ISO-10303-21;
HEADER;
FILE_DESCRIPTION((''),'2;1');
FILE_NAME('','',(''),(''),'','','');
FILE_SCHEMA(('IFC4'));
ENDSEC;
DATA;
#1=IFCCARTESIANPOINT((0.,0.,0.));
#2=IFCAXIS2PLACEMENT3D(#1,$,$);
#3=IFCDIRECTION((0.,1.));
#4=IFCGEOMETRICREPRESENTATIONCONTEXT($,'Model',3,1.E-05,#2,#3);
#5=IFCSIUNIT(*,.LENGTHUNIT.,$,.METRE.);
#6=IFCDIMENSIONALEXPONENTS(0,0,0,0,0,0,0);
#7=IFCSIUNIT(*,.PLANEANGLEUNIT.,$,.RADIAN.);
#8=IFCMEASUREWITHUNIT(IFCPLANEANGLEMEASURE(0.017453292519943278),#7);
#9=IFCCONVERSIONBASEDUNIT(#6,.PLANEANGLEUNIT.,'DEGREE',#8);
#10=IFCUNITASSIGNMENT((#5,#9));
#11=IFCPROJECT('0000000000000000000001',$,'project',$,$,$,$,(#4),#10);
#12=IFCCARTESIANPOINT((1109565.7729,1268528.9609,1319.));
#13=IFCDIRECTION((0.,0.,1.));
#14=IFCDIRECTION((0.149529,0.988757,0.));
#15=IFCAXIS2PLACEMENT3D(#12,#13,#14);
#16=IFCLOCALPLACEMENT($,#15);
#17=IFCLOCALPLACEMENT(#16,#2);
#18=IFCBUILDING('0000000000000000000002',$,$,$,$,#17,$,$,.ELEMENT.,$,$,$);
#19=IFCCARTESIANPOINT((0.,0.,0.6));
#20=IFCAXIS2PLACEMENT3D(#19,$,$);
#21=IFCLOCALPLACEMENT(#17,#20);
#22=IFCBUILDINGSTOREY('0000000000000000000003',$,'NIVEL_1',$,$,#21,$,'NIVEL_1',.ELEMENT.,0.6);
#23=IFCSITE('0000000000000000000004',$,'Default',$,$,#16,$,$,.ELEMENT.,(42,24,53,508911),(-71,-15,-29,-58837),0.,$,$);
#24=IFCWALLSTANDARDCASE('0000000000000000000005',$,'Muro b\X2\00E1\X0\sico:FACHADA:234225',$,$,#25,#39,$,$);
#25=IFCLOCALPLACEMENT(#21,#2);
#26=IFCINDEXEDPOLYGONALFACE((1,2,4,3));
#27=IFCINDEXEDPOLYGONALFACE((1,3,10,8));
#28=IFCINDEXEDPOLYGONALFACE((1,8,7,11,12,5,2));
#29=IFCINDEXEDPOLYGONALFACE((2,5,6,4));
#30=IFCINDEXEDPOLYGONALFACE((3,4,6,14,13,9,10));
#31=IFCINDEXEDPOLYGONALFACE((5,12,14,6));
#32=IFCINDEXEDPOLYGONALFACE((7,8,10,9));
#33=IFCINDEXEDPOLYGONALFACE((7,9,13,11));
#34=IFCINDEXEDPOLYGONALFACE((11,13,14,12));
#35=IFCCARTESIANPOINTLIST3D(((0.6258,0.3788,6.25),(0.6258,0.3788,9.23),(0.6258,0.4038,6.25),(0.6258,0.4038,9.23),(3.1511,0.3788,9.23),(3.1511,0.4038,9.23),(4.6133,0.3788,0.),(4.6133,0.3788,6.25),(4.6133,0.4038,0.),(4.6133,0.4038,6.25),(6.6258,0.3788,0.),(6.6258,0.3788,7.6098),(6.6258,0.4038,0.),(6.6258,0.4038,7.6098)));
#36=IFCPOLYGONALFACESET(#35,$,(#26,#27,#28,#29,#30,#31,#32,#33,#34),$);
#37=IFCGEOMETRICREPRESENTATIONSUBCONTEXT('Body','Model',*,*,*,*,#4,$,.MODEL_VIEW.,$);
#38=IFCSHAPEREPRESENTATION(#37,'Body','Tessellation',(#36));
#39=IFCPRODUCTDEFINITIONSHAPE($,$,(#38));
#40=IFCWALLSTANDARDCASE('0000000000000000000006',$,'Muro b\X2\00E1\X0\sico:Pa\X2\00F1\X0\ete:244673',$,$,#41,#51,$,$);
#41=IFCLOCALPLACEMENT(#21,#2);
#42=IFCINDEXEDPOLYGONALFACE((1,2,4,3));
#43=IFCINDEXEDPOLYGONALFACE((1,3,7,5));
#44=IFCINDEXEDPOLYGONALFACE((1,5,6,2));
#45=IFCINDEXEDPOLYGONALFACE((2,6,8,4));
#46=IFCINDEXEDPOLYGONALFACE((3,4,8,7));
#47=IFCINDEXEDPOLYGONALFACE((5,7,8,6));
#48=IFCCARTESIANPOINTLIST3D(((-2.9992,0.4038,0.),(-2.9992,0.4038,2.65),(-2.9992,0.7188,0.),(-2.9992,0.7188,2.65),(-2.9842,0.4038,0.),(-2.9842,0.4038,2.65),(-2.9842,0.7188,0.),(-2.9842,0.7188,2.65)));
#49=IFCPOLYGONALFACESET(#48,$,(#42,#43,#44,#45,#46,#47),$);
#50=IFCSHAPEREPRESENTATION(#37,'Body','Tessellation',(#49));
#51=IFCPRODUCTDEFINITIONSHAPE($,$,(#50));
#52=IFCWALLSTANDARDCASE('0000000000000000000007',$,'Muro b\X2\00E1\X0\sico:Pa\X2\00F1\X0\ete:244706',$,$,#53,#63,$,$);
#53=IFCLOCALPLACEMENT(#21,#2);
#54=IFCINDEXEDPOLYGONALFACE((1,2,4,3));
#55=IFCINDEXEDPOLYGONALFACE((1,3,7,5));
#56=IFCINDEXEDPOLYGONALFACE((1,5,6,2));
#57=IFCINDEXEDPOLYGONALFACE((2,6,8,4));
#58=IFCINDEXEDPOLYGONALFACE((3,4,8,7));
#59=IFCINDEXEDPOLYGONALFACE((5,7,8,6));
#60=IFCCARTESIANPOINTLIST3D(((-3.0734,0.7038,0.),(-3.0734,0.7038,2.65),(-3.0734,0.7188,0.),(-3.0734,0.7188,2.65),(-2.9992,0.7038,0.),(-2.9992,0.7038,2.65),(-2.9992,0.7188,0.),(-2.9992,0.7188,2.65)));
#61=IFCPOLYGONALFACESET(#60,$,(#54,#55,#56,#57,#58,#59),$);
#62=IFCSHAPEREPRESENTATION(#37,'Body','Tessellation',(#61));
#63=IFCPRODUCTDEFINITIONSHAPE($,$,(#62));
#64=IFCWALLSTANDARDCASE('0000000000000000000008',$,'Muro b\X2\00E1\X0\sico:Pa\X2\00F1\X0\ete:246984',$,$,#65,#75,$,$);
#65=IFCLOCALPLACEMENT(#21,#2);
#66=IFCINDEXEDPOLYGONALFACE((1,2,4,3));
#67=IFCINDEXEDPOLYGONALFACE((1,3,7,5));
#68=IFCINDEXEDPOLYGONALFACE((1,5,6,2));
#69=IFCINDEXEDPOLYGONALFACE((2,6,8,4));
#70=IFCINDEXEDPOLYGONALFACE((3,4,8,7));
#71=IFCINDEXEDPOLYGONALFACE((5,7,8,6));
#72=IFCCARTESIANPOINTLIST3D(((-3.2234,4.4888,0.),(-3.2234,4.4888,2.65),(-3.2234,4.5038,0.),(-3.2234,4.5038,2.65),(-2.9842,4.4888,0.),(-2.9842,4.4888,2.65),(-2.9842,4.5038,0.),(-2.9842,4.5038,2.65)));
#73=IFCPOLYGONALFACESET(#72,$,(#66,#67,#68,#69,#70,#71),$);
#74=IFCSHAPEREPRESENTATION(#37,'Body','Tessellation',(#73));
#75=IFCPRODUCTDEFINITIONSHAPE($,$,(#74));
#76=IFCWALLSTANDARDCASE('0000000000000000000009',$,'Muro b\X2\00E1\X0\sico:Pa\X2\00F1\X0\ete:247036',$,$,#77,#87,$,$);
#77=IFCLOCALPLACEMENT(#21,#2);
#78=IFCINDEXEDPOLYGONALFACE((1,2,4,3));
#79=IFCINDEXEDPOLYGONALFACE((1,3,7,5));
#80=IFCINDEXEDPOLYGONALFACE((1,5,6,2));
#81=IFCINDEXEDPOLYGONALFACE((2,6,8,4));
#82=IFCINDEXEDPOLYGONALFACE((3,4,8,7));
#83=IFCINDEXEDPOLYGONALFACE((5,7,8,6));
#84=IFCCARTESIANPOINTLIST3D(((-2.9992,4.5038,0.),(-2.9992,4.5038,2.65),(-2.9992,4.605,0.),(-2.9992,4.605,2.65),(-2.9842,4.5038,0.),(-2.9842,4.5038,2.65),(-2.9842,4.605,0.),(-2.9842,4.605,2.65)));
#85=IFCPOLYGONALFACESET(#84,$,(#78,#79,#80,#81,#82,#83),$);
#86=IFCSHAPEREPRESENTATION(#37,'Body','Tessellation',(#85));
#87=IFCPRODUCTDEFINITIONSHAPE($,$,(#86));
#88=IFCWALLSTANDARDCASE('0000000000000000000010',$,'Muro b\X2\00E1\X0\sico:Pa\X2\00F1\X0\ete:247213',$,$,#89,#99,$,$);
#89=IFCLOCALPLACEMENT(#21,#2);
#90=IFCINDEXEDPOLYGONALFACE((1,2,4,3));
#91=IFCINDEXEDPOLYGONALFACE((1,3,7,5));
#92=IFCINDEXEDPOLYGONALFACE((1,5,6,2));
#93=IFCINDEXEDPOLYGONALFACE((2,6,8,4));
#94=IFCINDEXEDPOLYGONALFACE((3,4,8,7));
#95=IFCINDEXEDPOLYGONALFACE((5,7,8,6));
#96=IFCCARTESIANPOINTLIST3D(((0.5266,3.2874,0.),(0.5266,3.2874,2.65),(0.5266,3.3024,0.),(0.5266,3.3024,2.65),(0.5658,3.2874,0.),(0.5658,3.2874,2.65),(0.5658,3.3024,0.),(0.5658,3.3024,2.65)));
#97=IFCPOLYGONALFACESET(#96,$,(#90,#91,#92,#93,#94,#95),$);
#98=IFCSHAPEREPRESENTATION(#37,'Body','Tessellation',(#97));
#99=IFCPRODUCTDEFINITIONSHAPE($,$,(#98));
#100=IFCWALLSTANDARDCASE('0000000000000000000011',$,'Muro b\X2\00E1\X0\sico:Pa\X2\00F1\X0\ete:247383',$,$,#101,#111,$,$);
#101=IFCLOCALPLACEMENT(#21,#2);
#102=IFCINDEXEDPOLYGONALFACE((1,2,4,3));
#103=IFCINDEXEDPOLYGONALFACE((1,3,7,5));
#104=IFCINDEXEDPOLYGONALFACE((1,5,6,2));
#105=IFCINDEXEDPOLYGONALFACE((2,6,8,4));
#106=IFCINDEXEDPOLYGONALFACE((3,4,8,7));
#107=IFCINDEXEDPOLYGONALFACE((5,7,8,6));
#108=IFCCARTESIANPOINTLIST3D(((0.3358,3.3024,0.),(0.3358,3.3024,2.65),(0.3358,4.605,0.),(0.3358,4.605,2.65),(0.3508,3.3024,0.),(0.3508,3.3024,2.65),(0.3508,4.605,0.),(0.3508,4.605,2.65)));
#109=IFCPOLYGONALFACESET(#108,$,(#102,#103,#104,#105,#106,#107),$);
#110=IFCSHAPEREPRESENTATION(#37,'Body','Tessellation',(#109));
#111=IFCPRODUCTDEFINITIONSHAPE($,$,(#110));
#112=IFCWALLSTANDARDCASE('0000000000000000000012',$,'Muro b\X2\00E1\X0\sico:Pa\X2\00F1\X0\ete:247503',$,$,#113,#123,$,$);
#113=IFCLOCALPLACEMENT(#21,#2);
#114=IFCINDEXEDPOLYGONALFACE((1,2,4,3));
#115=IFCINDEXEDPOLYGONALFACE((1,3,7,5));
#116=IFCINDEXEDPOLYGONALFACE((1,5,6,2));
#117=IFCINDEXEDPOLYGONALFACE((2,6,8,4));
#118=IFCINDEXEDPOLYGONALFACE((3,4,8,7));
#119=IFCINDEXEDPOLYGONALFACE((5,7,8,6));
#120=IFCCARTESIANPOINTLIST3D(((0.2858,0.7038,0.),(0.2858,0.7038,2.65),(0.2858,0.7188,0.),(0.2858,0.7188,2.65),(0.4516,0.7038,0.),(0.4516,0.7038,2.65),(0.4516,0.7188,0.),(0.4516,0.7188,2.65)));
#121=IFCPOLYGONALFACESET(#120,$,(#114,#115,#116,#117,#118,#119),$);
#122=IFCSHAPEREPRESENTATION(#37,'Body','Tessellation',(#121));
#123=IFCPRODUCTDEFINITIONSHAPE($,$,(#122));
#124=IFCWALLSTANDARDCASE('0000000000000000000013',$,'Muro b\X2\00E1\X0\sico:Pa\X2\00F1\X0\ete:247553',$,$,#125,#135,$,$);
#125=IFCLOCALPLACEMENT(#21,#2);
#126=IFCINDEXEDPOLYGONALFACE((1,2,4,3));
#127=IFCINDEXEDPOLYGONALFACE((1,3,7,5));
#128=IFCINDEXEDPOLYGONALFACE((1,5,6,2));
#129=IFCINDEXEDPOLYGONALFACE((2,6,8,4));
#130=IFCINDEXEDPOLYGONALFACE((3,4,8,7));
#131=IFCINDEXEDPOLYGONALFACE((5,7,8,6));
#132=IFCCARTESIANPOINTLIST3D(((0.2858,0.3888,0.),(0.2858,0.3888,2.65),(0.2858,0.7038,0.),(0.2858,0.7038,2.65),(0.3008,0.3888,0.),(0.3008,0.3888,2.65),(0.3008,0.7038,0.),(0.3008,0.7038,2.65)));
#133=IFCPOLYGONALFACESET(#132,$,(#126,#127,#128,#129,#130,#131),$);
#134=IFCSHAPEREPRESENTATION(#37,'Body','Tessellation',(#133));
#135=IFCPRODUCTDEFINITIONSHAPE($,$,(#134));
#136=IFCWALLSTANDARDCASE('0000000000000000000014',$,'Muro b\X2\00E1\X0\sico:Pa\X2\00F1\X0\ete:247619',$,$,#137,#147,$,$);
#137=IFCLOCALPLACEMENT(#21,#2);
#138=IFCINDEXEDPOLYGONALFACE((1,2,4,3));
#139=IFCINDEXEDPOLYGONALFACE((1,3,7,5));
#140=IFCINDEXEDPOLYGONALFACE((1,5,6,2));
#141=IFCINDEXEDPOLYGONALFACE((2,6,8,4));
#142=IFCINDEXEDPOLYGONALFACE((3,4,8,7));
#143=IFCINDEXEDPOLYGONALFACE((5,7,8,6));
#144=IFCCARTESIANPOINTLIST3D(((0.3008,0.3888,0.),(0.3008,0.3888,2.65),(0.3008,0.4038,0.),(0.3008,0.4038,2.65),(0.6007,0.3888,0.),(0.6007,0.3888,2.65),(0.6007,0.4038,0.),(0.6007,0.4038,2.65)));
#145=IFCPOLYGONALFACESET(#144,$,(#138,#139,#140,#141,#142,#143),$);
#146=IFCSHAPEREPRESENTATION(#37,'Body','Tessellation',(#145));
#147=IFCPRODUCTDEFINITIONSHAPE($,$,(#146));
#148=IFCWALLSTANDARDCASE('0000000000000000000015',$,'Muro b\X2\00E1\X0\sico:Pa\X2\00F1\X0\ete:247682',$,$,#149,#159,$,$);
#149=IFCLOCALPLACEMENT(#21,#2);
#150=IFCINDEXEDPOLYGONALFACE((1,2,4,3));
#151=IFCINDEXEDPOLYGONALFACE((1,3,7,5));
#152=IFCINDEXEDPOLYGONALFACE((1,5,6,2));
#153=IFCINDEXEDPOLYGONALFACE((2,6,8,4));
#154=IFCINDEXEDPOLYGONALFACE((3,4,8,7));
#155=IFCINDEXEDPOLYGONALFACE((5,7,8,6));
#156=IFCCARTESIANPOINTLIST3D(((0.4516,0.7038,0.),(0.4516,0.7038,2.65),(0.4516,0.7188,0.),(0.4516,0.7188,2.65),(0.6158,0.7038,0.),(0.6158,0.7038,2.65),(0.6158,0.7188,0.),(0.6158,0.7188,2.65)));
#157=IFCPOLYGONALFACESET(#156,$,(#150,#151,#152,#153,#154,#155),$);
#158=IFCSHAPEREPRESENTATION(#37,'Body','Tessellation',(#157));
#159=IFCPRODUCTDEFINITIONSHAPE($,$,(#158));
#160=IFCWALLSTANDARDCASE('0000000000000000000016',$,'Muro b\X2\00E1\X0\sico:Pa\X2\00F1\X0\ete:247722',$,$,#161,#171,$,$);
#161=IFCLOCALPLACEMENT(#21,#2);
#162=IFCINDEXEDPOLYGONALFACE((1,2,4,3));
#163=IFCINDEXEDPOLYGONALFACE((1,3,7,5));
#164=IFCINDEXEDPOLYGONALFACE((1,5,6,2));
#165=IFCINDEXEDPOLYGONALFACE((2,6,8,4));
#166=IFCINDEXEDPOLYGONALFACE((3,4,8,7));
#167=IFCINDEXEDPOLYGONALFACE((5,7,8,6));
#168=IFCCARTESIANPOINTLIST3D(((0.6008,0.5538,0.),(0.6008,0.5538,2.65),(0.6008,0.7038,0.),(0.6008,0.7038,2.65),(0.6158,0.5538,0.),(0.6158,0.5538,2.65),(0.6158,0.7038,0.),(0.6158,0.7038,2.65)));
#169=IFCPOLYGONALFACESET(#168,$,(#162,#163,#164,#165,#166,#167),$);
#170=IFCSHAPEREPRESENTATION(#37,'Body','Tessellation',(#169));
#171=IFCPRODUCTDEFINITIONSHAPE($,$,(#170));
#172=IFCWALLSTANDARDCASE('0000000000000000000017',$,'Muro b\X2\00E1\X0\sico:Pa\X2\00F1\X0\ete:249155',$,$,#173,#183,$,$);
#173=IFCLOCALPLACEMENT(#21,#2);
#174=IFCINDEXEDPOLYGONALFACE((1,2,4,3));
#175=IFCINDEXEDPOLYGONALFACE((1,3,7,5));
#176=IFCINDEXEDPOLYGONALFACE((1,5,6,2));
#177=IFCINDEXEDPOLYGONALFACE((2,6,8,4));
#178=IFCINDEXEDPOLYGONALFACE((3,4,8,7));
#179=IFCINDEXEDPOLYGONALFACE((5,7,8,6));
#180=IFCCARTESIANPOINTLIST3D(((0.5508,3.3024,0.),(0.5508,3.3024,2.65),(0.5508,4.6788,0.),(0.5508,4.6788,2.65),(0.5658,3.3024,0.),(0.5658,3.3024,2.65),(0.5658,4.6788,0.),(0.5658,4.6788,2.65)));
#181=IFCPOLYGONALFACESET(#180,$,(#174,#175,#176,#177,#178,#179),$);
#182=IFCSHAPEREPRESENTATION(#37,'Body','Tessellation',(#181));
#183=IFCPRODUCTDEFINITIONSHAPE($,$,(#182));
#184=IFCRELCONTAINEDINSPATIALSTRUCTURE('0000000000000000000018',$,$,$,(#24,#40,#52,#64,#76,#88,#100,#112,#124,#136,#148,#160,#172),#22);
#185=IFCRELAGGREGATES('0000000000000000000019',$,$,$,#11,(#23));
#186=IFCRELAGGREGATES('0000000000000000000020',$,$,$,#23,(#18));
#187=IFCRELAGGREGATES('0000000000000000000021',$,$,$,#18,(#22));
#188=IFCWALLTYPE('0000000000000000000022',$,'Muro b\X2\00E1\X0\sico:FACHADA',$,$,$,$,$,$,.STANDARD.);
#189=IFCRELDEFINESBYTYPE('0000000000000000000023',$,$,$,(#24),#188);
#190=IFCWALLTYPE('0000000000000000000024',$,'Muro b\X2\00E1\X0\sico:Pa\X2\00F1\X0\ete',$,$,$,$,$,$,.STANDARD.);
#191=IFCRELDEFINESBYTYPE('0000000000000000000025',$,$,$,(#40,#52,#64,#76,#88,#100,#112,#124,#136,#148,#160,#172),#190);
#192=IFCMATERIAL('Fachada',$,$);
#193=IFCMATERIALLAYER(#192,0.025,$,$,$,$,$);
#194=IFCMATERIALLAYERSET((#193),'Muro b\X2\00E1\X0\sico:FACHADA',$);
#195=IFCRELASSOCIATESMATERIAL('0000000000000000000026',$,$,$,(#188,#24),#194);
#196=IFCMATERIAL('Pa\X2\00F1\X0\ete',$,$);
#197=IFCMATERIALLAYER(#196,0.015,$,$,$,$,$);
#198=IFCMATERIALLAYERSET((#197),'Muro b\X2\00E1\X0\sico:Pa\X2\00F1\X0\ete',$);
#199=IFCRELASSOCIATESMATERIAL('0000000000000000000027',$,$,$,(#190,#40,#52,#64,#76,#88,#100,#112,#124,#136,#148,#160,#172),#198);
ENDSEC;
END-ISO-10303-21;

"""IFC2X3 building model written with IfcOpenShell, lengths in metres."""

from ifc_helpers import new_model, entity, si_unit, converted_unit, direction, frame, frame_2d, origin, origin_2d_with_axis, place, context, subcontext, project, spatial, rectangle, extrude, clip, halfspace, material, layer, layer_set, layer_usage, type_object, element, save


model = new_model("IFC2X3")

# Units and contexts
model_context = context("Model", 3, precision=1e-05, world=origin(), true_north=direction((0.0, 1.0)))
body_context = subcontext(model_context, "Body", "Model", "MODEL_VIEW")
ifc_project = project(units=[si_unit("LENGTHUNIT", "METRE"), converted_unit("PLANEANGLEUNIT", "DEGREE", entity("IfcPlaneAngleMeasure", 0.017453292519943278), si_unit("PLANEANGLEUNIT", "RADIAN"), dimensions=[0, 0, 0, 0, 0, 0, 0])], contexts=[model_context])

# Site, building, storey
site_placement = place(None, frame((1109565.7729, 1268528.9609, 1319.0), z_axis=(0.0, 0.0, 1.0), x_axis=(0.149529, 0.988757, 0.0)))
site = spatial("IfcSite", under=ifc_project, at=site_placement, Name="Default", CompositionType="ELEMENT", RefLatitude=(42, 24, 53, 508911), RefLongitude=(-71, -15, -29, -58837), RefElevation=0.0)
building_placement = place(site_placement, origin())
building = spatial("IfcBuilding", under=site, at=building_placement, CompositionType="ELEMENT")
storey_placement = place(building_placement, frame((0.0, 0.0, 0.6)))
storey = spatial("IfcBuildingStorey", under=building, at=storey_placement, Name="NIVEL_1", LongName="NIVEL_1", CompositionType="ELEMENT", Elevation=0.6)

# Shared definitions
ifc_material_1 = material(Name="Pañete")

# Wall, opening
ifc_material_2 = material(Name="Fachada")
ifc_layer_1 = layer(ifc_material_2, 0.025)
ifc_layer_set_1 = layer_set([ifc_layer_1], Name="Muro básico:FACHADA")
ifc_layer_usage_1 = layer_usage(ifc_layer_set_1, "AXIS2", "POSITIVE", -0.0125)
wall_type_1 = type_object("IfcWallType", Name="Muro básico:FACHADA", PredefinedType="STANDARD", material=ifc_layer_set_1)
wall_1_placement = place(storey_placement, frame((0.6258, 0.3913, 0.0)))
wall_1 = element("IfcWallStandardCase", 1, at=wall_1_placement, inside=storey, type_object=wall_type_1, material=ifc_layer_usage_1, Name="Muro básico:FACHADA:234225", context=body_context, shape_type="Clipping", body=[
    clip(extrude(rectangle(XDim=6.0, YDim=0.025, at=frame_2d((3.0, 0.0), x_axis=(-1.0, 0.0))), origin(), (0.0, 0.0, 1.0), 9.23), halfspace(frame((2.5254, -0.0125, 9.23), z_axis=(0.422613, 0.0, 0.90631), x_axis=(0.0, 1.0, 0.0)), False)),
])
opening_1_placement = place(wall_1_placement, origin())
element("IfcOpeningElement", 2, at=opening_1_placement, cuts=wall_1, ObjectType="Opening", context=body_context, shape_type="SweptSolid", body=[
    extrude(rectangle(XDim=6.25, YDim=3.9875, at=origin_2d_with_axis()), frame((1.9938, 0.0125, 3.125), z_axis=(0.0, -1.0, 0.0), x_axis=(0.0, 0.0, -1.0)), (0.0, 0.0, 1.0), 0.025),
])

# Walls
ifc_layer_2 = layer(ifc_material_1, 0.015)
ifc_layer_set_2 = layer_set([ifc_layer_2], Name="Muro básico:Pañete")
ifc_layer_usage_2 = layer_usage(ifc_layer_set_2, "AXIS2", "POSITIVE", -0.0075)
wall_type_2 = type_object("IfcWallType", Name="Muro básico:Pañete", PredefinedType="STANDARD", material=ifc_layer_set_2)
wall_2_placement = place(storey_placement, frame((-2.9917, 0.4038, 0.0), z_axis=(0.0, 0.0, 1.0), x_axis=(0.0, 1.0, 0.0)))
element("IfcWallStandardCase", 3, at=wall_2_placement, inside=storey, type_object=wall_type_2, material=ifc_layer_usage_2, Name="Muro básico:Pañete:244673", context=body_context, shape_type="SweptSolid", body=[
    extrude(rectangle(XDim=0.315, YDim=0.015, at=frame_2d((0.1575, 0.0), x_axis=(-1.0, 0.0))), origin(), (0.0, 0.0, 1.0), 2.65),
])
ifc_layer_usage_3 = layer_usage(ifc_layer_set_2, "AXIS2", "POSITIVE", -0.0075)
wall_3_placement = place(storey_placement, frame((-2.9992, 0.7113, 0.0), z_axis=(0.0, 0.0, 1.0), x_axis=(-1.0, 0.0, 0.0)))
element("IfcWallStandardCase", 4, at=wall_3_placement, inside=storey, type_object=wall_type_2, material=ifc_layer_usage_3, Name="Muro básico:Pañete:244706", context=body_context, shape_type="SweptSolid", body=[
    extrude(rectangle(XDim=0.0741, YDim=0.015, at=frame_2d((0.0371, 0.0), x_axis=(-1.0, 0.0))), origin(), (0.0, 0.0, 1.0), 2.65),
])
ifc_layer_usage_4 = layer_usage(ifc_layer_set_2, "AXIS2", "POSITIVE", -0.0075)
wall_4_placement = place(storey_placement, frame((-3.2234, 4.4963, 0.0)))
element("IfcWallStandardCase", 5, at=wall_4_placement, inside=storey, type_object=wall_type_2, material=ifc_layer_usage_4, Name="Muro básico:Pañete:246984", context=body_context, shape_type="SweptSolid", body=[
    extrude(rectangle(XDim=0.2391, YDim=0.015, at=frame_2d((0.1196, 0.0), x_axis=(-1.0, 0.0))), origin(), (0.0, 0.0, 1.0), 2.65),
])
ifc_layer_usage_5 = layer_usage(ifc_layer_set_2, "AXIS2", "POSITIVE", -0.0075)
wall_5_placement = place(storey_placement, frame((-2.9917, 4.5038, 0.0), z_axis=(0.0, 0.0, 1.0), x_axis=(0.0, 1.0, 0.0)))
element("IfcWallStandardCase", 6, at=wall_5_placement, inside=storey, type_object=wall_type_2, material=ifc_layer_usage_5, Name="Muro básico:Pañete:247036", context=body_context, shape_type="SweptSolid", body=[
    extrude(rectangle(XDim=0.1012, YDim=0.015, at=frame_2d((0.0506, 0.0), x_axis=(-1.0, 0.0))), origin(), (0.0, 0.0, 1.0), 2.65),
])
ifc_layer_usage_6 = layer_usage(ifc_layer_set_2, "AXIS2", "NEGATIVE", 0.0075)
wall_6_placement = place(storey_placement, frame((0.5658, 3.2949, 0.0), z_axis=(0.0, 0.0, 1.0), x_axis=(-1.0, 0.0, 0.0)))
element("IfcWallStandardCase", 7, at=wall_6_placement, inside=storey, type_object=wall_type_2, material=ifc_layer_usage_6, Name="Muro básico:Pañete:247213", context=body_context, shape_type="SweptSolid", body=[
    extrude(rectangle(XDim=0.0391, YDim=0.015, at=frame_2d((0.0196, 0.0), x_axis=(-1.0, 0.0))), origin(), (0.0, 0.0, 1.0), 2.65),
])
ifc_layer_usage_7 = layer_usage(ifc_layer_set_2, "AXIS2", "NEGATIVE", 0.0075)
wall_7_placement = place(storey_placement, frame((0.3433, 3.3024, 0.0), z_axis=(0.0, 0.0, 1.0), x_axis=(0.0, 1.0, 0.0)))
element("IfcWallStandardCase", 8, at=wall_7_placement, inside=storey, type_object=wall_type_2, material=ifc_layer_usage_7, Name="Muro básico:Pañete:247383", context=body_context, shape_type="SweptSolid", body=[
    extrude(rectangle(XDim=1.3026, YDim=0.015, at=frame_2d((0.6513, 0.0), x_axis=(-1.0, 0.0))), origin(), (0.0, 0.0, 1.0), 2.65),
])
ifc_layer_usage_8 = layer_usage(ifc_layer_set_2, "AXIS2", "POSITIVE", -0.0075)
wall_8_placement = place(storey_placement, frame((0.4516, 0.7113, 0.0), z_axis=(0.0, 0.0, 1.0), x_axis=(-1.0, 0.0, 0.0)))
element("IfcWallStandardCase", 9, at=wall_8_placement, inside=storey, type_object=wall_type_2, material=ifc_layer_usage_8, Name="Muro básico:Pañete:247503", context=body_context, shape_type="SweptSolid", body=[
    extrude(rectangle(XDim=0.1659, YDim=0.015, at=frame_2d((0.0829, 0.0), x_axis=(-1.0, 0.0))), origin(), (0.0, 0.0, 1.0), 2.65),
])
ifc_layer_usage_9 = layer_usage(ifc_layer_set_2, "AXIS2", "POSITIVE", -0.0075)
wall_9_placement = place(storey_placement, frame((0.2933, 0.7038, 0.0), z_axis=(0.0, 0.0, 1.0), x_axis=(0.0, -1.0, 0.0)))
element("IfcWallStandardCase", 10, at=wall_9_placement, inside=storey, type_object=wall_type_2, material=ifc_layer_usage_9, Name="Muro básico:Pañete:247553", context=body_context, shape_type="SweptSolid", body=[
    extrude(rectangle(XDim=0.315, YDim=0.015, at=frame_2d((0.1575, 0.0), x_axis=(-1.0, 0.0))), origin(), (0.0, 0.0, 1.0), 2.65),
])
ifc_layer_usage_10 = layer_usage(ifc_layer_set_2, "AXIS2", "POSITIVE", -0.0075)
wall_10_placement = place(storey_placement, frame((0.3008, 0.3963, 0.0)))
element("IfcWallStandardCase", 11, at=wall_10_placement, inside=storey, type_object=wall_type_2, material=ifc_layer_usage_10, Name="Muro básico:Pañete:247619", context=body_context, shape_type="SweptSolid", body=[
    extrude(rectangle(XDim=0.3, YDim=0.015, at=frame_2d((0.15, 0.0), x_axis=(-1.0, 0.0))), origin(), (0.0, 0.0, 1.0), 2.65),
])
ifc_layer_usage_11 = layer_usage(ifc_layer_set_2, "AXIS2", "NEGATIVE", 0.0075)
wall_11_placement = place(storey_placement, frame((0.4516, 0.7113, 0.0)))
element("IfcWallStandardCase", 12, at=wall_11_placement, inside=storey, type_object=wall_type_2, material=ifc_layer_usage_11, Name="Muro básico:Pañete:247682", context=body_context, shape_type="SweptSolid", body=[
    extrude(rectangle(XDim=0.1641, YDim=0.015, at=frame_2d((0.0821, 0.0), x_axis=(-1.0, 0.0))), origin(), (0.0, 0.0, 1.0), 2.65),
])
ifc_layer_usage_12 = layer_usage(ifc_layer_set_2, "AXIS2", "NEGATIVE", 0.0075)
wall_12_placement = place(storey_placement, frame((0.6083, 0.7038, 0.0), z_axis=(0.0, 0.0, 1.0), x_axis=(0.0, -1.0, 0.0)))
element("IfcWallStandardCase", 13, at=wall_12_placement, inside=storey, type_object=wall_type_2, material=ifc_layer_usage_12, Name="Muro básico:Pañete:247722", context=body_context, shape_type="SweptSolid", body=[
    extrude(rectangle(XDim=0.15, YDim=0.015, at=frame_2d((0.075, 0.0), x_axis=(-1.0, 0.0))), origin(), (0.0, 0.0, 1.0), 2.65),
])
ifc_layer_usage_13 = layer_usage(ifc_layer_set_2, "AXIS2", "NEGATIVE", 0.0075)
wall_13_placement = place(storey_placement, frame((0.5583, 4.6788, 0.0), z_axis=(0.0, 0.0, 1.0), x_axis=(0.0, -1.0, 0.0)))
element("IfcWallStandardCase", 14, at=wall_13_placement, inside=storey, type_object=wall_type_2, material=ifc_layer_usage_13, Name="Muro básico:Pañete:249155", context=body_context, shape_type="SweptSolid", body=[
    extrude(rectangle(XDim=1.3764, YDim=0.015, at=frame_2d((0.6882, 0.0), x_axis=(-1.0, 0.0))), origin(), (0.0, 0.0, 1.0), 2.65),
])

save(model, "model.ifc")
